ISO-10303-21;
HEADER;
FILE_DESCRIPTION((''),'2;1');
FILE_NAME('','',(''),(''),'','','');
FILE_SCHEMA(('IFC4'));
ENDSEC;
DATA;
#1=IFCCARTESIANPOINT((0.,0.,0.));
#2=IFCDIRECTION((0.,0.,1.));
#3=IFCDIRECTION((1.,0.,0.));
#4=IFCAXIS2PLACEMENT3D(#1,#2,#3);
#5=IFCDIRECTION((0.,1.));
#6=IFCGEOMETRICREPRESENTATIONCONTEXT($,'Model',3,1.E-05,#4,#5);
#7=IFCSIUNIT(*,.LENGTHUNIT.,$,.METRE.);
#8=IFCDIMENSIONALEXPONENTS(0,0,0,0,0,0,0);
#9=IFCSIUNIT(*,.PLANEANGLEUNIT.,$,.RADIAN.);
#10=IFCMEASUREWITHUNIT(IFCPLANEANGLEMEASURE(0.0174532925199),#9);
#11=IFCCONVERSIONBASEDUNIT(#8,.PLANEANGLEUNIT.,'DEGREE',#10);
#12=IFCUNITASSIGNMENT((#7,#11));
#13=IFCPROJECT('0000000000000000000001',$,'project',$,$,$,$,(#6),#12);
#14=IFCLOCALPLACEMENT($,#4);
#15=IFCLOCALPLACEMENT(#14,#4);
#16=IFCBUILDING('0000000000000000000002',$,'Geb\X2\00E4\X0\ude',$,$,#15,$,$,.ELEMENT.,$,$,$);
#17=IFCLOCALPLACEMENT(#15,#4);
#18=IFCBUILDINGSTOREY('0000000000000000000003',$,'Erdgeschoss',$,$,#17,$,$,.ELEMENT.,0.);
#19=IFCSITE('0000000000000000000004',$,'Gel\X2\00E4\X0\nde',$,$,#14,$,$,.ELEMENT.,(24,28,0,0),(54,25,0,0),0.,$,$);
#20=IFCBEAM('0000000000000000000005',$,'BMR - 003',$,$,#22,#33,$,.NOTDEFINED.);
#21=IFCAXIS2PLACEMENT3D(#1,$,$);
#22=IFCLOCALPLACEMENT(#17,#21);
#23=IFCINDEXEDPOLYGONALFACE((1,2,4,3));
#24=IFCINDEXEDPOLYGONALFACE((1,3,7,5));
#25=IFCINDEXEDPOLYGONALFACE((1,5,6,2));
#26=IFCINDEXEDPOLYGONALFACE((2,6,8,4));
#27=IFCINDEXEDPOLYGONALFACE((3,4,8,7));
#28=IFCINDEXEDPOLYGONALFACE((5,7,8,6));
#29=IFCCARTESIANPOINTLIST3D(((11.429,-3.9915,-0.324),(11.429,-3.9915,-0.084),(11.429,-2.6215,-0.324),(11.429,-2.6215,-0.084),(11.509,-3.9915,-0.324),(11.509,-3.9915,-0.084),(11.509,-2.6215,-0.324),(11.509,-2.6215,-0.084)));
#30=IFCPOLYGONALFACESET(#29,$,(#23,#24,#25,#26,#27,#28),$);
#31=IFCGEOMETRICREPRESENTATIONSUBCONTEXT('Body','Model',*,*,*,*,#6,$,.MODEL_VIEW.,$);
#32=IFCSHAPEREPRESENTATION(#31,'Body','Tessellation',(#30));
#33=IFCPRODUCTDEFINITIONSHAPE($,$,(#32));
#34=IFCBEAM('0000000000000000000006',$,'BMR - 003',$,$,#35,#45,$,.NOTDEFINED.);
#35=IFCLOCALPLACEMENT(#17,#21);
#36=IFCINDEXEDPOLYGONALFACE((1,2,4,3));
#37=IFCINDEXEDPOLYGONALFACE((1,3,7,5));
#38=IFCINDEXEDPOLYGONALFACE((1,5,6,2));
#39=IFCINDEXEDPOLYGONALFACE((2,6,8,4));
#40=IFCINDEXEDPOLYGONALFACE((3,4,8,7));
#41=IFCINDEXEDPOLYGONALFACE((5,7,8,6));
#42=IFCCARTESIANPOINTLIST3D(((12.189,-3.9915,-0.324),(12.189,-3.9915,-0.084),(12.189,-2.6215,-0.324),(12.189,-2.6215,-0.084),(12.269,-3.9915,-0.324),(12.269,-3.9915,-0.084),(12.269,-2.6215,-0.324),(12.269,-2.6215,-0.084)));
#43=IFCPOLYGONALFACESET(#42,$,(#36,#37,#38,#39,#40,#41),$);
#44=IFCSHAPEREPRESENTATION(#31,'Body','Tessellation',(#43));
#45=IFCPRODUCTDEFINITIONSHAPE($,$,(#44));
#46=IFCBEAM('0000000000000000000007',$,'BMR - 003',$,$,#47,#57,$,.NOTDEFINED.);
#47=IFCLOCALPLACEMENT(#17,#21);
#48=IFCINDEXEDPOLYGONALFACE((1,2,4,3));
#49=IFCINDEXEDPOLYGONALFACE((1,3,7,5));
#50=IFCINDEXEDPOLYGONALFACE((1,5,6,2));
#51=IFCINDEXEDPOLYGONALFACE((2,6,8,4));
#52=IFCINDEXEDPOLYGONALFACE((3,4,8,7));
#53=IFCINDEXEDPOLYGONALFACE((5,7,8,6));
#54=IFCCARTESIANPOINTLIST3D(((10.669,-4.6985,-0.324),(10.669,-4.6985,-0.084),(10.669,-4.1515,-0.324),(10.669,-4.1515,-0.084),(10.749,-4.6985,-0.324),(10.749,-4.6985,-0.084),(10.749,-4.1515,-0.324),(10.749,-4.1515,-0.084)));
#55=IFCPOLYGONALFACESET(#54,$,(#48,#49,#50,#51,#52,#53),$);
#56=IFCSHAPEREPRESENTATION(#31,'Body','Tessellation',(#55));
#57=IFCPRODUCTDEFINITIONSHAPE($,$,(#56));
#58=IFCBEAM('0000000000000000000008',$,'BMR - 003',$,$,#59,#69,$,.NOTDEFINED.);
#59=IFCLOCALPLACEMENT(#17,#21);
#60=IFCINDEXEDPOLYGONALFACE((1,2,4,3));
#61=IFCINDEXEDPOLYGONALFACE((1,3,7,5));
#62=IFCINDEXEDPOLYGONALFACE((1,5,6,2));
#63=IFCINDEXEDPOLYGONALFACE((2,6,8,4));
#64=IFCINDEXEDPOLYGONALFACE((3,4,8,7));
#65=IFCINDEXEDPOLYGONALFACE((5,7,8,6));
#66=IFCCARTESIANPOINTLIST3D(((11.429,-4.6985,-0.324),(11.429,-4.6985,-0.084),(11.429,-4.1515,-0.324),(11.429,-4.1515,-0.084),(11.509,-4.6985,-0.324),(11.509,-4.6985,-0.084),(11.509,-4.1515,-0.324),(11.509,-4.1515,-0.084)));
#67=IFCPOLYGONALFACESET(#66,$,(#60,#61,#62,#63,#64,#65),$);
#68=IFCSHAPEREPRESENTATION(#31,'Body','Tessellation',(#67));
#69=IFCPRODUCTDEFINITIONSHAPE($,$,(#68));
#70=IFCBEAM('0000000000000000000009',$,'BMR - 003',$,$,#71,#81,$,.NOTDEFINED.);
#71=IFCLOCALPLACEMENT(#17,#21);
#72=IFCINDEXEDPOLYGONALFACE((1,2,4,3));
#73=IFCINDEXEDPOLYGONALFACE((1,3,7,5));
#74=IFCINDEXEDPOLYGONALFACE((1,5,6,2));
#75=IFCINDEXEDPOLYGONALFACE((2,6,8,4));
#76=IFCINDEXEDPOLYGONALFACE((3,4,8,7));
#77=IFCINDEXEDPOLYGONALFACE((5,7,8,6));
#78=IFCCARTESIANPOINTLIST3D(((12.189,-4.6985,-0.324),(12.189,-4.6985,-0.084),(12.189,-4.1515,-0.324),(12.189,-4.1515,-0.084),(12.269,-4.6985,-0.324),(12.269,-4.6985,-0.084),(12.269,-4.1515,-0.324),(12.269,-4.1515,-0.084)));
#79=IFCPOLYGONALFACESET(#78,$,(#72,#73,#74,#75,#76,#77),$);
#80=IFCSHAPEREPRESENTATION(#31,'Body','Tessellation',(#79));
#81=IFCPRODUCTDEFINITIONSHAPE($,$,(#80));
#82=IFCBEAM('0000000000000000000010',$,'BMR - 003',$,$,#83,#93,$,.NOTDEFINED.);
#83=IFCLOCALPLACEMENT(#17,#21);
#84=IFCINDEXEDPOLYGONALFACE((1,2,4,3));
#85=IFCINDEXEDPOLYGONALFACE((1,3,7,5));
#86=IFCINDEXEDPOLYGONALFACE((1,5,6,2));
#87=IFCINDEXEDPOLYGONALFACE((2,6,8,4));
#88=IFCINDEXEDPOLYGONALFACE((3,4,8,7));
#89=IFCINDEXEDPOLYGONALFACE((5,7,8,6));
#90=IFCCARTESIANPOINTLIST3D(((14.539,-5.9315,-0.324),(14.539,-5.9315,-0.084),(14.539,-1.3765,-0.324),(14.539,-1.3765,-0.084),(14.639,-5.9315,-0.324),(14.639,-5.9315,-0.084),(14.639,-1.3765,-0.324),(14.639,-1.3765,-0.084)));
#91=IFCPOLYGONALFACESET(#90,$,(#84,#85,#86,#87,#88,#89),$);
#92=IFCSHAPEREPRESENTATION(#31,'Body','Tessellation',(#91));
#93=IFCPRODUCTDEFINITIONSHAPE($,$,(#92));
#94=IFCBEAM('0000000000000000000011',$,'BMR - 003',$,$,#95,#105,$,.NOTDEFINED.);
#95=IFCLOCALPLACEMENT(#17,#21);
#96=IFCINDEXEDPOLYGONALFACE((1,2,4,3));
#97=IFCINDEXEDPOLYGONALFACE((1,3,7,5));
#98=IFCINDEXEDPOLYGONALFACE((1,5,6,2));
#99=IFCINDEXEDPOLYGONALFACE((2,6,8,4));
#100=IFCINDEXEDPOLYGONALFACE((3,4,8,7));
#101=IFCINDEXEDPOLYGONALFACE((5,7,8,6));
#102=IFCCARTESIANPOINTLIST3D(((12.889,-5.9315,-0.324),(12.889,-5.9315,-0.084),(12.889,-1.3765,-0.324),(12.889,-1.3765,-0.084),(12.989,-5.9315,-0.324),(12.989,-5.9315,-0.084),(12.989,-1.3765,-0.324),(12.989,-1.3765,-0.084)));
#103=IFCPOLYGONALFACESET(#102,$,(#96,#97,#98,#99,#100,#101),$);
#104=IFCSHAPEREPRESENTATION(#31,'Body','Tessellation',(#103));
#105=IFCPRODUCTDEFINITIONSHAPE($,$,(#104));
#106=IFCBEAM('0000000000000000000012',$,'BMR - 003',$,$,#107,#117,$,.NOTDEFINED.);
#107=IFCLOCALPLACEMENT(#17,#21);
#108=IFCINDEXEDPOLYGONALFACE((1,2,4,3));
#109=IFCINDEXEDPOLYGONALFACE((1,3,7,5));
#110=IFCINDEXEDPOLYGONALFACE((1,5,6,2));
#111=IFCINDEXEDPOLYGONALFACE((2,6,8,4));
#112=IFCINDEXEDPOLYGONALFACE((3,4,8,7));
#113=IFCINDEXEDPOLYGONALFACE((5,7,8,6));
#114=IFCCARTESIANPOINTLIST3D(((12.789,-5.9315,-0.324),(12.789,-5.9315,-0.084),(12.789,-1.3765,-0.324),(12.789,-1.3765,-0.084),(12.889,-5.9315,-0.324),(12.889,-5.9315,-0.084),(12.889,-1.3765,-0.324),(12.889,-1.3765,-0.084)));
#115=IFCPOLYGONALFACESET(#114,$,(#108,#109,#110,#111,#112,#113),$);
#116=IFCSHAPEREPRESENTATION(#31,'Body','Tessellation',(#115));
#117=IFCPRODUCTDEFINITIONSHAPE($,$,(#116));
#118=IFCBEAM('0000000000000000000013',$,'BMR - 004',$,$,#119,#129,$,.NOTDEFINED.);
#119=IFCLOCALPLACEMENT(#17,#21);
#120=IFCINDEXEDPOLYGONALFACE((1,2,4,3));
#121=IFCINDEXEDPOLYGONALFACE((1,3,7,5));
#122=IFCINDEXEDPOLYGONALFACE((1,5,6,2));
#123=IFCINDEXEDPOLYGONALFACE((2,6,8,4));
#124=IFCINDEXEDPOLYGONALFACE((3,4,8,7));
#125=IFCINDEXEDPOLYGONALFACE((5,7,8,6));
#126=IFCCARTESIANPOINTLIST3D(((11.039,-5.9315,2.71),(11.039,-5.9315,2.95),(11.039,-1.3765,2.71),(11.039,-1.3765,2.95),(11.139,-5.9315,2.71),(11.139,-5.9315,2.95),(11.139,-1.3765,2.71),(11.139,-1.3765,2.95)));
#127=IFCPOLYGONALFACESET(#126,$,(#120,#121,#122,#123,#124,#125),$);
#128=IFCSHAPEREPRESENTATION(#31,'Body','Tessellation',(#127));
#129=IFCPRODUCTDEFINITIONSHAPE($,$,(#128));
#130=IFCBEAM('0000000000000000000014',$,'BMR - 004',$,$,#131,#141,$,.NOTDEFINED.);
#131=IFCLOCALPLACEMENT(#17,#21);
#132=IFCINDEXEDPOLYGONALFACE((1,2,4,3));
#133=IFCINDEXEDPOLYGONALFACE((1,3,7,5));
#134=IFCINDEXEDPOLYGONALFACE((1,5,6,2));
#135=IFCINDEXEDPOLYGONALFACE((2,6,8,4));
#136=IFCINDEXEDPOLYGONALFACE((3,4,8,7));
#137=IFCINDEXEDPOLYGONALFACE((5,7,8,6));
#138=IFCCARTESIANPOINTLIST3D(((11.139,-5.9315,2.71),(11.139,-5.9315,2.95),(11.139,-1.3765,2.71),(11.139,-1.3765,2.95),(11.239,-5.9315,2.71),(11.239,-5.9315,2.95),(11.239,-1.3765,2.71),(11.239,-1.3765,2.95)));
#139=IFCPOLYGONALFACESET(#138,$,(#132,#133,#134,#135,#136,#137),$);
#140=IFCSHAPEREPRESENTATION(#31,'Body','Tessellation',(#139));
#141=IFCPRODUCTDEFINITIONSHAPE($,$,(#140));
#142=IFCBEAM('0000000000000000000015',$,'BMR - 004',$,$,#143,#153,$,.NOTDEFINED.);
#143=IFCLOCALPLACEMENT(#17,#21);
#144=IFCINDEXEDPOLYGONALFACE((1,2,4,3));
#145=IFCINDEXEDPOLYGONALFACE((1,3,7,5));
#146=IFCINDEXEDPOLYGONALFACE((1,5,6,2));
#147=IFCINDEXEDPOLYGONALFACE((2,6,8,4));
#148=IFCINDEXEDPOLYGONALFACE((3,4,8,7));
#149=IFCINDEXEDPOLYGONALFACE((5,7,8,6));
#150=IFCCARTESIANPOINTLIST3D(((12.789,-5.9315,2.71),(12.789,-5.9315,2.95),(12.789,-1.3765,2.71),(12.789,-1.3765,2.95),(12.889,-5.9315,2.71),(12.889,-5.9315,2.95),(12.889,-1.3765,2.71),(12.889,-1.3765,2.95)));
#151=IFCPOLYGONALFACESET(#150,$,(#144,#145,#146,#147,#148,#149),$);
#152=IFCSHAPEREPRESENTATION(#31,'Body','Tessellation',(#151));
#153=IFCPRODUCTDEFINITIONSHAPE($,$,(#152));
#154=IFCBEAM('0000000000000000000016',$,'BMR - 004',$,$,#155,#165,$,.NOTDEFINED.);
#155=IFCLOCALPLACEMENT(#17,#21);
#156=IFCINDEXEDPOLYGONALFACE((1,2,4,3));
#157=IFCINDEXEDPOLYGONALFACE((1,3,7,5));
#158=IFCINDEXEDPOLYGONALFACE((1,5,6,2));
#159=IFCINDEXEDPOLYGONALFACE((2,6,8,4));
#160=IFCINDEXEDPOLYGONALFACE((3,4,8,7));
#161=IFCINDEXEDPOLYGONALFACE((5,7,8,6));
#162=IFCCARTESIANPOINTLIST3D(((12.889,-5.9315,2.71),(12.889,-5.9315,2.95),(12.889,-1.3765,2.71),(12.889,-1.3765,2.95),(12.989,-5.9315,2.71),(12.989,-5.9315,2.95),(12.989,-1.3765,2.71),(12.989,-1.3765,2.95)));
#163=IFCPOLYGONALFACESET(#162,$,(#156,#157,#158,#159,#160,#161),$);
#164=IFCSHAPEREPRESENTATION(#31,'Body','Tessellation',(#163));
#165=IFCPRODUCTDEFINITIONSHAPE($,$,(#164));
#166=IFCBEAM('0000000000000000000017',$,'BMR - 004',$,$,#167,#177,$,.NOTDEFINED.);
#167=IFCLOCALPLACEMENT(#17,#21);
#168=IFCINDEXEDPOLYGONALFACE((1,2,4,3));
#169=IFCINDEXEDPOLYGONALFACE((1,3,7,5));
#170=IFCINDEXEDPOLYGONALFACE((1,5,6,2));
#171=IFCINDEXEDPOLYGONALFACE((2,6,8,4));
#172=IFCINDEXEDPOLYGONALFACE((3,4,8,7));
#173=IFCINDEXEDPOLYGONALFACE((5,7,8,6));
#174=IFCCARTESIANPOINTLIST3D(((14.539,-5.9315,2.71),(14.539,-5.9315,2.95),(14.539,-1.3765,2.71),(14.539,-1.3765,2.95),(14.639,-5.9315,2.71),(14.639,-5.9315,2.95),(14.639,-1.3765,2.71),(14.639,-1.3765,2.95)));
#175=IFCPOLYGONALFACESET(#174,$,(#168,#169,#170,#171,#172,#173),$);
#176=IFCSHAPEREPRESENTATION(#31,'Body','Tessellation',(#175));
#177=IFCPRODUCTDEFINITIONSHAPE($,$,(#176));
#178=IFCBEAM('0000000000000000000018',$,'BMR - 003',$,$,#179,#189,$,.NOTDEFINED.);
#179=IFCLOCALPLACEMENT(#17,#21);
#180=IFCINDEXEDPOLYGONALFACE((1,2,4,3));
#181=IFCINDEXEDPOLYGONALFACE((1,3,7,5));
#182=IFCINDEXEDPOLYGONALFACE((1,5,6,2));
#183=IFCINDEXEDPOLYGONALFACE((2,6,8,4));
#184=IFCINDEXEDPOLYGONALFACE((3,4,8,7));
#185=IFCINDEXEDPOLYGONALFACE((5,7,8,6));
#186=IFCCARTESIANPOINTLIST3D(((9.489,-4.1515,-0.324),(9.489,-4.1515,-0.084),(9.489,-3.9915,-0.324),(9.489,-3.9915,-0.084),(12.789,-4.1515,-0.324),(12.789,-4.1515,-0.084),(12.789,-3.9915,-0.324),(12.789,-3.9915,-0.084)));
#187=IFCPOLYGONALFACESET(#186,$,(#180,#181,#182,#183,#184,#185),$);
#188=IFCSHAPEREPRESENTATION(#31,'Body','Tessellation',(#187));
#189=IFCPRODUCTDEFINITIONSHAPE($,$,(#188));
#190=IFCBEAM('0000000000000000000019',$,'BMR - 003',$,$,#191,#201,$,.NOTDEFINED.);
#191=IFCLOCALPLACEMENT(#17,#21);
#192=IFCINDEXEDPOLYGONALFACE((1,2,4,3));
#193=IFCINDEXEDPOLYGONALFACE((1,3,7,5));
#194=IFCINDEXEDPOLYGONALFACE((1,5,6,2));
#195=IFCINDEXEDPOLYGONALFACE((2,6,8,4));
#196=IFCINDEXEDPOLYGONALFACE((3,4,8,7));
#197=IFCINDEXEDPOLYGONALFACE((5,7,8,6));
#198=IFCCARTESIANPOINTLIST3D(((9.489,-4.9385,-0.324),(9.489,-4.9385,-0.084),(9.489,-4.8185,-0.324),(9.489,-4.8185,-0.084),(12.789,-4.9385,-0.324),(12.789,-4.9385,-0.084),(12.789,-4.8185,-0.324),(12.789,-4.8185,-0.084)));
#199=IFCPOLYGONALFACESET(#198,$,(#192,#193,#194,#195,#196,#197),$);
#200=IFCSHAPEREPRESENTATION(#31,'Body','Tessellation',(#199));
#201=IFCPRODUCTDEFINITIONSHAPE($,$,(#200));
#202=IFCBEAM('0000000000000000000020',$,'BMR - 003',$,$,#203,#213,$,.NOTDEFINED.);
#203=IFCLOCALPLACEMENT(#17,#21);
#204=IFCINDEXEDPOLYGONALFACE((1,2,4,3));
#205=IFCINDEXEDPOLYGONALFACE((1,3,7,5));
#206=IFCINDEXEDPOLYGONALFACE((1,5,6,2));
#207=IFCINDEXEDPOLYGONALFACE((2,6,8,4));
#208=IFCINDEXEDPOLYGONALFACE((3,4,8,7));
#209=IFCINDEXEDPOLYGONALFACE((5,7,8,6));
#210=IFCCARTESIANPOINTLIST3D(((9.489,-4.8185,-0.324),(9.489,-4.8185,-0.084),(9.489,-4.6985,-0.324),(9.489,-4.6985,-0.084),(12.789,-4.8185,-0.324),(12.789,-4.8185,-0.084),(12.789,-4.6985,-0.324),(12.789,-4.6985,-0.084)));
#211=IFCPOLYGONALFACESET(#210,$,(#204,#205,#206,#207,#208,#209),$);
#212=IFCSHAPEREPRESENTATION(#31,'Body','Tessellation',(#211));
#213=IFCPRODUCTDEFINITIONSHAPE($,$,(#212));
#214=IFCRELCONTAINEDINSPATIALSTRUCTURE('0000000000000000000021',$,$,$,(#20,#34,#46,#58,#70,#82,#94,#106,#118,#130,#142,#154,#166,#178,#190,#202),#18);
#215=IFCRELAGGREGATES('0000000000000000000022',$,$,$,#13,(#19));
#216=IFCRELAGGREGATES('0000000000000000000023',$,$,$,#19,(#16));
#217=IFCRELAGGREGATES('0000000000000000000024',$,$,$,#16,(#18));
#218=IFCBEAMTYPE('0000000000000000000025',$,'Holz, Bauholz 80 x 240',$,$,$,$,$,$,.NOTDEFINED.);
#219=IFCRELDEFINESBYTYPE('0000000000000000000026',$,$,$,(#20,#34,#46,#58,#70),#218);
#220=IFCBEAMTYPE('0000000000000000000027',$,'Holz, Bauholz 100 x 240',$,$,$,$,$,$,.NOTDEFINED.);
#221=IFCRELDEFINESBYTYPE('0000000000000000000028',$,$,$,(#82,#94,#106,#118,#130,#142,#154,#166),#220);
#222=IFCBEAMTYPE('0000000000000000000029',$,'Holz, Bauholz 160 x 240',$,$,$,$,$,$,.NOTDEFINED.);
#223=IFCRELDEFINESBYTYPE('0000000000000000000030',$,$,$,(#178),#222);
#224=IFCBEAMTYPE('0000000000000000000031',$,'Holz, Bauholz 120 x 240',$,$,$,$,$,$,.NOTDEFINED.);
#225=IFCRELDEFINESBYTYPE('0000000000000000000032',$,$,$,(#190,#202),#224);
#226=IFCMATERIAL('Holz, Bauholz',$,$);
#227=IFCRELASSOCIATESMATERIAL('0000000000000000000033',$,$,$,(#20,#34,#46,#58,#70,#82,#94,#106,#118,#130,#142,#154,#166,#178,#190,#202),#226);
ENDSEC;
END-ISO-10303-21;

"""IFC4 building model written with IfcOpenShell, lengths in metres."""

from ifc_helpers import new_model, entity, si_unit, converted_unit, direction, frame, frame_2d, origin_with_axes, place, context, subcontext, project, spatial, rectangle, extrude, material, type_object, element, save


model = new_model("IFC4")

# Units and contexts
model_context = context("Model", 3, precision=1e-05, world=origin_with_axes(), true_north=direction((0.0, 1.0)))
body_context = subcontext(model_context, "Body", "Model", "MODEL_VIEW")
ifc_project = project(units=[si_unit("LENGTHUNIT", "METRE"), converted_unit("PLANEANGLEUNIT", "DEGREE", entity("IfcPlaneAngleMeasure", 0.0174532925199), si_unit("PLANEANGLEUNIT", "RADIAN"), dimensions=[0, 0, 0, 0, 0, 0, 0])], contexts=[model_context])

# Site, building, storey
site_placement = place(None, origin_with_axes())
site = spatial("IfcSite", under=ifc_project, at=site_placement, Name="Gelände", CompositionType="ELEMENT", RefLatitude=(24, 28, 0, 0), RefLongitude=(54, 25, 0, 0), RefElevation=0.0)
building_placement = place(site_placement, origin_with_axes())
building = spatial("IfcBuilding", under=site, at=building_placement, Name="Gebäude", CompositionType="ELEMENT")
storey_placement = place(building_placement, origin_with_axes())
storey = spatial("IfcBuildingStorey", under=building, at=storey_placement, Name="Erdgeschoss", CompositionType="ELEMENT", Elevation=0.0)

# Shared definitions
ifc_material_1 = material(Name="Holz, Bauholz")

# Beams
beam_type_1 = type_object("IfcBeamType", Name="Holz, Bauholz 80 x 240", PredefinedType="NOTDEFINED")
for number, where, z_axis, x_axis, name in (
    (1, (11.469, -3.9915, -0.084), (0.0, 0.0, 1.0), (1.0, 0.0, 0.0), "BMR - 003"),
    (2, (12.229, -3.9915, -0.084), (0.0, 0.0, 1.0), (1.0, 0.0, 0.0), "BMR - 003"),
):
    element("IfcBeam", number, at=place(storey_placement, frame(where, z_axis=z_axis, x_axis=x_axis)), inside=storey, type_object=beam_type_1, material=ifc_material_1, Name=name, PredefinedType="NOTDEFINED", context=body_context, shape_type="SweptSolid", body=[
        extrude(rectangle(XDim=0.24, YDim=0.08, at=frame_2d((-0.12, 0.0), x_axis=(1.0, 0.0))), frame((0.0, 0.0, 0.0), z_axis=(0.0, 1.0, 0.0), x_axis=(0.0, 0.0, 1.0)), (0.0, 0.0, 1.0), 1.37),
    ])
for number, where, z_axis, x_axis, name in (
    (3, (10.709, -4.6985, -0.084), (0.0, 0.0, 1.0), (1.0, 0.0, 0.0), "BMR - 003"),
    (4, (11.469, -4.6985, -0.084), (0.0, 0.0, 1.0), (1.0, 0.0, 0.0), "BMR - 003"),
    (5, (12.229, -4.6985, -0.084), (0.0, 0.0, 1.0), (1.0, 0.0, 0.0), "BMR - 003"),
):
    element("IfcBeam", number, at=place(storey_placement, frame(where, z_axis=z_axis, x_axis=x_axis)), inside=storey, type_object=beam_type_1, material=ifc_material_1, Name=name, PredefinedType="NOTDEFINED", context=body_context, shape_type="SweptSolid", body=[
        extrude(rectangle(XDim=0.24, YDim=0.08, at=frame_2d((-0.12, 0.0), x_axis=(1.0, 0.0))), frame((0.0, 0.0, 0.0), z_axis=(0.0, 1.0, 0.0), x_axis=(0.0, 0.0, 1.0)), (0.0, 0.0, 1.0), 0.547),
    ])
beam_type_2 = type_object("IfcBeamType", Name="Holz, Bauholz 100 x 240", PredefinedType="NOTDEFINED")
for number, where, z_axis, x_axis, name in (
    (6, (14.589, -5.9315, -0.084), (0.0, 0.0, 1.0), (1.0, 0.0, 0.0), "BMR - 003"),
    (7, (12.939, -5.9315, -0.084), (0.0, 0.0, 1.0), (1.0, 0.0, 0.0), "BMR - 003"),
    (8, (12.839, -5.9315, -0.084), (0.0, 0.0, 1.0), (1.0, 0.0, 0.0), "BMR - 003"),
):
    element("IfcBeam", number, at=place(storey_placement, frame(where, z_axis=z_axis, x_axis=x_axis)), inside=storey, type_object=beam_type_2, material=ifc_material_1, Name=name, PredefinedType="NOTDEFINED", context=body_context, shape_type="SweptSolid", body=[
        extrude(rectangle(XDim=0.24, YDim=0.1, at=frame_2d((-0.12, 0.0), x_axis=(1.0, 0.0))), frame((0.0, 0.0, 0.0), z_axis=(0.0, 1.0, 0.0), x_axis=(0.0, 0.0, 1.0)), (0.0, 0.0, 1.0), 4.555),
    ])
for number, where, z_axis, x_axis, name in (
    (9, (11.089, -5.9315, 2.95), (0.0, 0.0, 1.0), (1.0, 0.0, 0.0), "BMR - 004"),
    (10, (11.189, -5.9315, 2.95), (0.0, 0.0, 1.0), (1.0, 0.0, 0.0), "BMR - 004"),
    (11, (12.839, -5.9315, 2.95), (0.0, 0.0, 1.0), (1.0, 0.0, 0.0), "BMR - 004"),
    (12, (12.939, -5.9315, 2.95), (0.0, 0.0, 1.0), (1.0, 0.0, 0.0), "BMR - 004"),
    (13, (14.589, -5.9315, 2.95), (0.0, 0.0, 1.0), (1.0, 0.0, 0.0), "BMR - 004"),
):
    element("IfcBeam", number, at=place(storey_placement, frame(where, z_axis=z_axis, x_axis=x_axis)), inside=storey, type_object=beam_type_2, material=ifc_material_1, Name=name, PredefinedType="NOTDEFINED", context=body_context, shape_type="SweptSolid", body=[
        extrude(rectangle(XDim=0.24, YDim=0.1, at=frame_2d((-0.12, 0.0), x_axis=(1.0, 0.0))), frame((0.0, 0.0, 0.0), z_axis=(0.0, 1.0, 0.0), x_axis=(0.0, 0.0, 1.0)), (0.0, 0.0, 1.0), 4.555),
    ])
beam_type_3 = type_object("IfcBeamType", Name="Holz, Bauholz 160 x 240", PredefinedType="NOTDEFINED")
beam_placement = place(storey_placement, frame((12.789, -4.0715, -0.084), z_axis=(0.0, 0.0, 1.0), x_axis=(0.0, 1.0, 0.0)))
element("IfcBeam", 14, at=beam_placement, inside=storey, type_object=beam_type_3, material=ifc_material_1, Name="BMR - 003", PredefinedType="NOTDEFINED", context=body_context, shape_type="SweptSolid", body=[
    extrude(rectangle(XDim=0.24, YDim=0.16, at=frame_2d((-0.12, 0.0), x_axis=(1.0, 0.0))), frame((0.0, 0.0, 0.0), z_axis=(0.0, 1.0, 0.0), x_axis=(0.0, 0.0, 1.0)), (0.0, 0.0, 1.0), 3.3),
])
beam_type_4 = type_object("IfcBeamType", Name="Holz, Bauholz 120 x 240", PredefinedType="NOTDEFINED")
for number, where, z_axis, x_axis, name in (
    (15, (12.789, -4.8785, -0.084), (0.0, 0.0, 1.0), (0.0, 1.0, 0.0), "BMR - 003"),
    (16, (12.789, -4.7585, -0.084), (0.0, 0.0, 1.0), (0.0, 1.0, 0.0), "BMR - 003"),
):
    element("IfcBeam", number, at=place(storey_placement, frame(where, z_axis=z_axis, x_axis=x_axis)), inside=storey, type_object=beam_type_4, material=ifc_material_1, Name=name, PredefinedType="NOTDEFINED", context=body_context, shape_type="SweptSolid", body=[
        extrude(rectangle(XDim=0.24, YDim=0.12, at=frame_2d((-0.12, 0.0), x_axis=(1.0, 0.0))), frame((0.0, 0.0, 0.0), z_axis=(0.0, 1.0, 0.0), x_axis=(0.0, 0.0, 1.0)), (0.0, 0.0, 1.0), 3.3),
    ])

save(model, "model.ifc")
